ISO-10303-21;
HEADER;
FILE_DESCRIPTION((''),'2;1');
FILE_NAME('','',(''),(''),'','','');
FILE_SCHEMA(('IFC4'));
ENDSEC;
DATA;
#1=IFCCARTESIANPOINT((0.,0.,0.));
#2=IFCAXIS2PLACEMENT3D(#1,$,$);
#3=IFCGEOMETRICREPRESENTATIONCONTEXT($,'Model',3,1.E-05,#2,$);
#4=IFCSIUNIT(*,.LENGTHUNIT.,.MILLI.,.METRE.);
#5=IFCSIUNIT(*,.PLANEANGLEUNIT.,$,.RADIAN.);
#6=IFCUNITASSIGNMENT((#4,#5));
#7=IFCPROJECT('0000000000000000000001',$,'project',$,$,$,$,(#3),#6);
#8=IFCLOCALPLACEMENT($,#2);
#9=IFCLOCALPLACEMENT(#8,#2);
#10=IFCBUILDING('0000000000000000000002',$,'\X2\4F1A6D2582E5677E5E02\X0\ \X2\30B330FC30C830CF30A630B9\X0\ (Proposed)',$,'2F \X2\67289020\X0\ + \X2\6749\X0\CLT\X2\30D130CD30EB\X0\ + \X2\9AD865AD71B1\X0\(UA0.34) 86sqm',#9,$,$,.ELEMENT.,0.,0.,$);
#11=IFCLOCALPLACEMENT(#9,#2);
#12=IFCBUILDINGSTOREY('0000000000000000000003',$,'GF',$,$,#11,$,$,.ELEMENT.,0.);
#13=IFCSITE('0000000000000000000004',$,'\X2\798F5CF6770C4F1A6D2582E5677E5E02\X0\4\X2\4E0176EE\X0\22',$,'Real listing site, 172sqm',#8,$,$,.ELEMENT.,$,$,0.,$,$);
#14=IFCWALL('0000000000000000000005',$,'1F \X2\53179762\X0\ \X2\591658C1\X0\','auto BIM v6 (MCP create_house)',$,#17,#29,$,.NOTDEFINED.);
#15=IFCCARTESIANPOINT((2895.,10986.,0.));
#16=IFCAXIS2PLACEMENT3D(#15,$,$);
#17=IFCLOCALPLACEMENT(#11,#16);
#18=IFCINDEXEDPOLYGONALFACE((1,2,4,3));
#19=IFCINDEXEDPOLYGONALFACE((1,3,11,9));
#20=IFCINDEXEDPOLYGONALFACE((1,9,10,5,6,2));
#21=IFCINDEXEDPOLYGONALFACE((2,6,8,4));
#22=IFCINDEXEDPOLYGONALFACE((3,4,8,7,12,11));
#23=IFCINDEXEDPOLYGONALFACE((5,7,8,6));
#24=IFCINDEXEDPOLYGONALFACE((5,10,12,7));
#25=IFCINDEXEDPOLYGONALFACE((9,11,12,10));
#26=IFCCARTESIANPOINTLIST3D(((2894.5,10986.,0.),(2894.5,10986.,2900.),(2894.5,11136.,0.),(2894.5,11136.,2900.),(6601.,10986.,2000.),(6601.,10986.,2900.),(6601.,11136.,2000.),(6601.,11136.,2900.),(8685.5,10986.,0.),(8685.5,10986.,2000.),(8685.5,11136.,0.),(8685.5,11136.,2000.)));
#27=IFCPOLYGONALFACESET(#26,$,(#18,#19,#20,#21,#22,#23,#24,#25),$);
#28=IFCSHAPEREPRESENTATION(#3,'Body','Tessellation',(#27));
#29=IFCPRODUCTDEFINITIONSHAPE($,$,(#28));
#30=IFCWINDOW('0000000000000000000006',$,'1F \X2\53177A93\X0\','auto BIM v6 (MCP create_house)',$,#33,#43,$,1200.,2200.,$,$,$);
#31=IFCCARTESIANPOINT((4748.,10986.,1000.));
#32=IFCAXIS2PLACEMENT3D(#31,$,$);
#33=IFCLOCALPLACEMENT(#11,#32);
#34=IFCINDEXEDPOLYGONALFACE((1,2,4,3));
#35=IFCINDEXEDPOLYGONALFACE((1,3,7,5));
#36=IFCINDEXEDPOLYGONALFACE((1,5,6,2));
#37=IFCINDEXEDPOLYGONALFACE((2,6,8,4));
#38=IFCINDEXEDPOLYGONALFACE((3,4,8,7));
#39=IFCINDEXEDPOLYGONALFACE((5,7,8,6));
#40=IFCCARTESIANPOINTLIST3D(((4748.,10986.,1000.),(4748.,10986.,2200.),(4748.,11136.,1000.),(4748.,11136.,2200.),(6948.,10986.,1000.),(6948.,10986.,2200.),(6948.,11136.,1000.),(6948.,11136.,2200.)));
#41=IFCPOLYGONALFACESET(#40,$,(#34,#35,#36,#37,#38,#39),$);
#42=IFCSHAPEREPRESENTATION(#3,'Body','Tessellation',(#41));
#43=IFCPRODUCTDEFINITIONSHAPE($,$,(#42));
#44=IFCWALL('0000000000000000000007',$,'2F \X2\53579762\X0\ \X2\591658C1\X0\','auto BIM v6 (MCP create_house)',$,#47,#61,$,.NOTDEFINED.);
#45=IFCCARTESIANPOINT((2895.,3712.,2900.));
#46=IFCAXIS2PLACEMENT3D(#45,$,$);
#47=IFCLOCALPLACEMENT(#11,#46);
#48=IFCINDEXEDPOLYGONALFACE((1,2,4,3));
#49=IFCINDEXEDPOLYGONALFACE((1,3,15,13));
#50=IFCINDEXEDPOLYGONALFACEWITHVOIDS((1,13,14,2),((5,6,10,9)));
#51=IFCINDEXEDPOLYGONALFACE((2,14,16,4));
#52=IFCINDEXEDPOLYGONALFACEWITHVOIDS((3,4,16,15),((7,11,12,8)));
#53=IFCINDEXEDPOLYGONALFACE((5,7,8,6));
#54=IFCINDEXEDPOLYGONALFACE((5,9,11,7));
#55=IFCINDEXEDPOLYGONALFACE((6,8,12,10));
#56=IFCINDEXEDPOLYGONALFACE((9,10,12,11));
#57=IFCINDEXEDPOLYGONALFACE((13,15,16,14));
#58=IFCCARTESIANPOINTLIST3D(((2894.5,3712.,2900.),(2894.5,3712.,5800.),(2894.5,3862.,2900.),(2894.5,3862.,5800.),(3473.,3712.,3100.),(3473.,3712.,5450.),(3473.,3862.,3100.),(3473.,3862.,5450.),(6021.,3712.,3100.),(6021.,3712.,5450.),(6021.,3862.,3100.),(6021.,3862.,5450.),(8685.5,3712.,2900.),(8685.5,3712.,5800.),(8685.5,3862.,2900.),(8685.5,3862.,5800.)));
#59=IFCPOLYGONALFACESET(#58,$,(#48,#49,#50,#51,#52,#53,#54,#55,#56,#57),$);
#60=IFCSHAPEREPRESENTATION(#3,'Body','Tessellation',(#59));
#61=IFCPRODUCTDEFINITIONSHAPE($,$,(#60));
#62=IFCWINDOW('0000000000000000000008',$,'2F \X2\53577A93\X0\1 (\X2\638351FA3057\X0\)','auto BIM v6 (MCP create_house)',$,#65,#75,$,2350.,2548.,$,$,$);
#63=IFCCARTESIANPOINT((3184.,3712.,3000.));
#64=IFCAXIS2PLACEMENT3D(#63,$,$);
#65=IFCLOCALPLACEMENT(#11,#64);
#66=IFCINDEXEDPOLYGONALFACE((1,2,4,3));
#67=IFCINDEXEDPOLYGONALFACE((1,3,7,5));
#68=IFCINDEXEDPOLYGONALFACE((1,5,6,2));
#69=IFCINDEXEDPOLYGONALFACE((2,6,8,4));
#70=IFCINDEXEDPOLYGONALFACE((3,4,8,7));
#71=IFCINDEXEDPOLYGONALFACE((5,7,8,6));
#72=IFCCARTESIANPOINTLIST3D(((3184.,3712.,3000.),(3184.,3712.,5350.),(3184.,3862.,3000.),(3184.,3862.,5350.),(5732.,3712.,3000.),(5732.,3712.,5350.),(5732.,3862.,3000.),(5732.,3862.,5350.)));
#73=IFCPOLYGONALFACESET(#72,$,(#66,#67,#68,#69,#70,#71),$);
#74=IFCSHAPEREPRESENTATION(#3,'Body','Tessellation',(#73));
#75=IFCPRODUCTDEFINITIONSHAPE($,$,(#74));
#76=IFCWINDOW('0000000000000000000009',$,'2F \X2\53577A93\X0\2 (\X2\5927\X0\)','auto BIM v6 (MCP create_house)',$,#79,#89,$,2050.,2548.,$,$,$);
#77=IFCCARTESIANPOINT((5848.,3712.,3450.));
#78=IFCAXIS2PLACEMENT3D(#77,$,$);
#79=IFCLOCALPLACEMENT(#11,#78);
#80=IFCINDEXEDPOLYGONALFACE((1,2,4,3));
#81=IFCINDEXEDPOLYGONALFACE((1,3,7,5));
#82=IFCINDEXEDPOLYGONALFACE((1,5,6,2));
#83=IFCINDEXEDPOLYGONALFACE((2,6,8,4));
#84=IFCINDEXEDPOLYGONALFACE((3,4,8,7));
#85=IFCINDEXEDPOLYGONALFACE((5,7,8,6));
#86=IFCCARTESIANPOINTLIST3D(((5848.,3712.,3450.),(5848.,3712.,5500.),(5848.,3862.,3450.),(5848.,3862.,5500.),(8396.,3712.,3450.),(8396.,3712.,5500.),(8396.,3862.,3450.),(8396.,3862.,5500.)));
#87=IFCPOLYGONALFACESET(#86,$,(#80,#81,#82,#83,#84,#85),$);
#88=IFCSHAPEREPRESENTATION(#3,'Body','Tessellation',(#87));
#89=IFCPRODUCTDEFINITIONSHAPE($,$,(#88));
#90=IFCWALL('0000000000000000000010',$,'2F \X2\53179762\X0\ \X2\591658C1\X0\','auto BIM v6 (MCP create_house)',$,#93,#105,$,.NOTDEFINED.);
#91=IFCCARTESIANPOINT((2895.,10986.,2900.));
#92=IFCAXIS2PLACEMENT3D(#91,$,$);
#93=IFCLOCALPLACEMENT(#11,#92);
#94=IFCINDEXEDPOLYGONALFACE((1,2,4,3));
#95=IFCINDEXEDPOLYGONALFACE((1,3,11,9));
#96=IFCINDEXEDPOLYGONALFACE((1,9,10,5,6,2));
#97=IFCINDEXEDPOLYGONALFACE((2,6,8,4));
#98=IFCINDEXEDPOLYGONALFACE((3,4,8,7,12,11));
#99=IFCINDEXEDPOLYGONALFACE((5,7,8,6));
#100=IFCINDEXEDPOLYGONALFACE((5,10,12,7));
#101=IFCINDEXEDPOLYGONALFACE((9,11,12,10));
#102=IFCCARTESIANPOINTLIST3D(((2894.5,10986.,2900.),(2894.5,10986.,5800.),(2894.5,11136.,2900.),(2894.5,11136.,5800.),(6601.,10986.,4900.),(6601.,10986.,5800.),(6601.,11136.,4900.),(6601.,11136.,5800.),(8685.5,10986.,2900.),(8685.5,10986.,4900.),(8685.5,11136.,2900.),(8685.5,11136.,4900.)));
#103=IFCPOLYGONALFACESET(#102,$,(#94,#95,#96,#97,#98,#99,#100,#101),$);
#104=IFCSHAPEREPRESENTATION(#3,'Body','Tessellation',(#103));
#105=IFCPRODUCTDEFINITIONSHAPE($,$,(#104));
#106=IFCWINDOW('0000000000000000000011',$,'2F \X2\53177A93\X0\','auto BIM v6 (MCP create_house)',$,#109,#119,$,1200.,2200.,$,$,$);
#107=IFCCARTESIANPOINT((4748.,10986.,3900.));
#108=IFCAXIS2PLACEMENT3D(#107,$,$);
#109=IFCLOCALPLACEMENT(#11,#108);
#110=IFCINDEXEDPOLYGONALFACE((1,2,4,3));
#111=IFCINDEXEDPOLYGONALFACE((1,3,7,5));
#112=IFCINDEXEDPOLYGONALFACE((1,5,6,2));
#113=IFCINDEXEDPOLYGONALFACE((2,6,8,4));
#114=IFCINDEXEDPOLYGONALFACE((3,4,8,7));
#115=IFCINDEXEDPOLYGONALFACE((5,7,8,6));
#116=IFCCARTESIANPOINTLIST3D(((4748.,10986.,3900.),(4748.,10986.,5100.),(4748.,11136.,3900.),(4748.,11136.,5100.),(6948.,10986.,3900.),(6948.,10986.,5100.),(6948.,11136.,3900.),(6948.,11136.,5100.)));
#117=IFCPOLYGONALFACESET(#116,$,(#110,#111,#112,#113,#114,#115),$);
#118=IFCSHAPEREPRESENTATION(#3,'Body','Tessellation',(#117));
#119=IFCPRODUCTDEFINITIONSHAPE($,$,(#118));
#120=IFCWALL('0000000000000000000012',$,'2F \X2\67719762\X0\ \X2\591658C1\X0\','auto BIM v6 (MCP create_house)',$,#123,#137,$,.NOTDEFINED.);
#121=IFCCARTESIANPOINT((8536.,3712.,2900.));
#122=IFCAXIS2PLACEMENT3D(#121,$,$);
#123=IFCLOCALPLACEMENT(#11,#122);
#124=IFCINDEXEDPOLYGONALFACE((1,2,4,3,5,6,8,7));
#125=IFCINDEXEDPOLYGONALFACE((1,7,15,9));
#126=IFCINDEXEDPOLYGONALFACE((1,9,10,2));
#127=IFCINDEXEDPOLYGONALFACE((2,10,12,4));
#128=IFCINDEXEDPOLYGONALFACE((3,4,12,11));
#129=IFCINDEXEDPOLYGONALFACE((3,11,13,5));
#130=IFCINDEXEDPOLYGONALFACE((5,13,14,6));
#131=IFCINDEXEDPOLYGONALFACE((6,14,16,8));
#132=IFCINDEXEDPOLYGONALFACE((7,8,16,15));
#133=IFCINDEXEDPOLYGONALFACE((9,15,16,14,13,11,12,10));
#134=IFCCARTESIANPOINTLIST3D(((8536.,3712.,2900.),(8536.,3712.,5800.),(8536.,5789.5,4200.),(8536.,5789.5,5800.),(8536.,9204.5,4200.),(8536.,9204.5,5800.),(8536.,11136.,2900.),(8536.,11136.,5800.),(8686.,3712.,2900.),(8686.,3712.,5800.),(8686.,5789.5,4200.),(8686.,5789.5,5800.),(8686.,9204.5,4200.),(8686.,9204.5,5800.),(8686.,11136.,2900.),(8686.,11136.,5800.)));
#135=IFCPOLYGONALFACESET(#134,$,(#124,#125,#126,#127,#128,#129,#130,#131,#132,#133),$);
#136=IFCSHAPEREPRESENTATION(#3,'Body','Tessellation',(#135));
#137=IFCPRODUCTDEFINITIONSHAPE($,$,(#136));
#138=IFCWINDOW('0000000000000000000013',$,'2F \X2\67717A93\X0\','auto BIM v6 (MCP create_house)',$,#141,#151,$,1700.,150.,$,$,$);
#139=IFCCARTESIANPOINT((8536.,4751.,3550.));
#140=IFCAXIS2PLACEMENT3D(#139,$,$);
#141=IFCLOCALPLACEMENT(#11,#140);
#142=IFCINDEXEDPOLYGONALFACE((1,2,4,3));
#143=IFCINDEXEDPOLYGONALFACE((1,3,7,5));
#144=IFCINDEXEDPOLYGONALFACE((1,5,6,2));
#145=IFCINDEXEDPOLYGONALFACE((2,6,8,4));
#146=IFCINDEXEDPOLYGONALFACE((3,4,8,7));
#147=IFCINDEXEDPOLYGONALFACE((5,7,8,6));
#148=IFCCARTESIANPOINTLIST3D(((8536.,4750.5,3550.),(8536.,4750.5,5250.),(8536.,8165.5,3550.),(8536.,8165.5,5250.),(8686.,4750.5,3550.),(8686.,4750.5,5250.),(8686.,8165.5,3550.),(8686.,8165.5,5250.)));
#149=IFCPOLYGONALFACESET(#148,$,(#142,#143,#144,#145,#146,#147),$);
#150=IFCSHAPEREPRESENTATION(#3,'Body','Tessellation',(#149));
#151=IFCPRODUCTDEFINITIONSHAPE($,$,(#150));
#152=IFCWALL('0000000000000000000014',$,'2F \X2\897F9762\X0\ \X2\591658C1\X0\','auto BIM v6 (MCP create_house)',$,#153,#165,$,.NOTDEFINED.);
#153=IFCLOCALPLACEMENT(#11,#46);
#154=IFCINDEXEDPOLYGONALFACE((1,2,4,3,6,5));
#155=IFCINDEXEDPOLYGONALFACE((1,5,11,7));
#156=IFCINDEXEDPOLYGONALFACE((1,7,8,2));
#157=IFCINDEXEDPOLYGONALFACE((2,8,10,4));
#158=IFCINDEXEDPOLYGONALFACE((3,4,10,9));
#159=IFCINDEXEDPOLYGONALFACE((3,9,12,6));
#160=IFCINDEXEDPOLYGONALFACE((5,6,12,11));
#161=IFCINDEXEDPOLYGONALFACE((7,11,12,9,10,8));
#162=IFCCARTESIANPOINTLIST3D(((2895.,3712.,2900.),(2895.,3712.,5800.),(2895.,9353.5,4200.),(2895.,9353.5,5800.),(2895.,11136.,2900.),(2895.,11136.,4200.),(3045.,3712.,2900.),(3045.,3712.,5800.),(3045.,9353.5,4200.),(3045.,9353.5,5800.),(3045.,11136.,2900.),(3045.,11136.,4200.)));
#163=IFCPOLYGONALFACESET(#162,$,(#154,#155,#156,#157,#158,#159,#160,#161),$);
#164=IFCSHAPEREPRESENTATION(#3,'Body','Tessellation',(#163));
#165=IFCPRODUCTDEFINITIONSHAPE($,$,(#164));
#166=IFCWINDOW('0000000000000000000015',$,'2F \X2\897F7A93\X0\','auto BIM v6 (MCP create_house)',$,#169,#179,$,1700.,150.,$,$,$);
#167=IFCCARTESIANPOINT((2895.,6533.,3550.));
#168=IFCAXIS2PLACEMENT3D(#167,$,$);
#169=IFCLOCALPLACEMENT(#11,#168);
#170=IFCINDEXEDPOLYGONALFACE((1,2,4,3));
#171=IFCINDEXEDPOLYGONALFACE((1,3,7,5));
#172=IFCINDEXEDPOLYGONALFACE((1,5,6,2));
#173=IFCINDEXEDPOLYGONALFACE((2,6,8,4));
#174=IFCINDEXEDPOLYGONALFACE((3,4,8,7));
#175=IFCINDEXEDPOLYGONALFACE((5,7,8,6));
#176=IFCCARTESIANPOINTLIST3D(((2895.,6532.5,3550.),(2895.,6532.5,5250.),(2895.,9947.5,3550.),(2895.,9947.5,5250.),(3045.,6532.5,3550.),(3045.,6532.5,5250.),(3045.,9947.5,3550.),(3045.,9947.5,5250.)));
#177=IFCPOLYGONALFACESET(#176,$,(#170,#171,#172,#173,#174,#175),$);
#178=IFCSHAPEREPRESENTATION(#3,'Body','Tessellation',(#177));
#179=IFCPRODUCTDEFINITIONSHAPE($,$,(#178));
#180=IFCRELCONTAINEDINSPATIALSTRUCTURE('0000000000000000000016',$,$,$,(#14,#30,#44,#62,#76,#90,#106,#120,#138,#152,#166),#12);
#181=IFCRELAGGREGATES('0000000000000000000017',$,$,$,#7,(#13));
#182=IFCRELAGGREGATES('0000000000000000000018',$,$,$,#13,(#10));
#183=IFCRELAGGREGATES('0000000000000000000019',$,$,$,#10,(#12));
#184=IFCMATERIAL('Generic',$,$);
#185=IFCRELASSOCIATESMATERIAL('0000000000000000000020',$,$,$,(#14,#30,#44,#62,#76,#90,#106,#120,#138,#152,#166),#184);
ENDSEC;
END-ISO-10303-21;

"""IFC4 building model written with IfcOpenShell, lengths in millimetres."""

from ifc_helpers import new_model, si_unit, frame, frame_2d, origin, place, context, project, spatial, rectangle, extrude, material, element, fill, save


model = new_model("IFC4")

# Units and contexts
model_context = context("Model", 3, precision=1e-05, world=origin())
ifc_project = project(units=[si_unit("LENGTHUNIT", "METRE", prefix="MILLI"), si_unit("PLANEANGLEUNIT", "RADIAN")], contexts=[model_context])

# Site, building, storey
site_placement = place(None, origin())
site = spatial("IfcSite", under=ifc_project, at=site_placement, Name="福島県会津若松市4丁目22", ObjectType="Real listing site, 172sqm", CompositionType="ELEMENT", RefElevation=0.0)
building_placement = place(site_placement, origin())
building = spatial("IfcBuilding", under=site, at=building_placement, Name="会津若松市 コートハウス (Proposed)", ObjectType="2F 木造 + 杉CLTパネル + 高断熱(UA0.34) 86sqm", CompositionType="ELEMENT", ElevationOfRefHeight=0.0, ElevationOfTerrain=0.0)
storey_placement = place(building_placement, origin())
storey = spatial("IfcBuildingStorey", under=building, at=storey_placement, Name="GF", CompositionType="ELEMENT", Elevation=0.0)

# Wall, opening, window
ifc_material = material(Name="Generic")
wall_1_placement = place(storey_placement, frame((2895.0, 10986.0, 0.0)))
wall_1 = element("IfcWall", 1, at=wall_1_placement, inside=storey, material=ifc_material, Name="1F 北面 外壁", Description="auto BIM v6 (MCP create_house)", PredefinedType="NOTDEFINED", context=model_context, shape_type="SweptSolid", body=[
    extrude(rectangle(XDim=5791.0, YDim=150.0, at=frame_2d((2895.0, 75.0))), frame((2895.0, 10986.0, 0.0)), (0.0, 0.0, 1.0), 2900.0),
])
opening_1_placement = place(storey_placement, frame((4748.0, 10986.0, 1000.0)))
opening_1 = element("IfcOpeningElement", 2, at=opening_1_placement, cuts=wall_1, PredefinedType="NOTDEFINED", context=model_context, shape_type="SweptSolid", body=[
    extrude(rectangle(XDim=2200.0, YDim=150.0, at=frame_2d((1100.0, 75.0))), frame((4748.0, 10986.0, 1000.0)), (0.0, 0.0, 1.0), 1200.0),
])
window_1_placement = place(storey_placement, frame((4748.0, 10986.0, 1000.0)))
window_1 = element("IfcWindow", 3, at=window_1_placement, inside=storey, material=ifc_material, Name="1F 北窓", Description="auto BIM v6 (MCP create_house)", OverallHeight=1200.0, OverallWidth=2200.0, context=model_context, shape_type="SweptSolid", body=[
    extrude(rectangle(XDim=2200.0, YDim=150.0, at=frame_2d((1100.0, 75.0))), frame((4748.0, 10986.0, 1000.0)), (0.0, 0.0, 1.0), 1200.0),
])
fill(opening_1, window_1)

# Wall, openings, windows
wall_2_placement = place(storey_placement, frame((2895.0, 3712.0, 2900.0)))
wall_2 = element("IfcWall", 4, at=wall_2_placement, inside=storey, material=ifc_material, Name="2F 南面 外壁", Description="auto BIM v6 (MCP create_house)", PredefinedType="NOTDEFINED", context=model_context, shape_type="SweptSolid", body=[
    extrude(rectangle(XDim=5791.0, YDim=150.0, at=frame_2d((2895.0, 75.0))), frame((2895.0, 3712.0, 2900.0)), (0.0, 0.0, 1.0), 2900.0),
])
opening_2_placement = place(storey_placement, frame((3184.0, 3712.0, 3000.0)))
opening_2 = element("IfcOpeningElement", 5, at=opening_2_placement, cuts=wall_2, PredefinedType="NOTDEFINED", context=model_context, shape_type="SweptSolid", body=[
    extrude(rectangle(XDim=2548.0, YDim=150.0, at=frame_2d((1274.0, 75.0))), frame((3184.0, 3712.0, 3000.0)), (0.0, 0.0, 1.0), 2350.0),
])
opening_3_placement = place(storey_placement, frame((5848.0, 3712.0, 3450.0)))
opening_3 = element("IfcOpeningElement", 6, at=opening_3_placement, cuts=wall_2, PredefinedType="NOTDEFINED", context=model_context, shape_type="SweptSolid", body=[
    extrude(rectangle(XDim=2548.0, YDim=150.0, at=frame_2d((1274.0, 75.0))), frame((5848.0, 3712.0, 3450.0)), (0.0, 0.0, 1.0), 2050.0),
])
window_2_placement = place(storey_placement, frame((3184.0, 3712.0, 3000.0)))
window_2 = element("IfcWindow", 7, at=window_2_placement, inside=storey, material=ifc_material, Name="2F 南窓1 (掃出し)", Description="auto BIM v6 (MCP create_house)", OverallHeight=2350.0, OverallWidth=2548.0, context=model_context, shape_type="SweptSolid", body=[
    extrude(rectangle(XDim=2548.0, YDim=150.0, at=frame_2d((1274.0, 75.0))), frame((3184.0, 3712.0, 3000.0)), (0.0, 0.0, 1.0), 2350.0),
])
fill(opening_2, window_2)
window_3_placement = place(storey_placement, frame((5848.0, 3712.0, 3450.0)))
window_3 = element("IfcWindow", 8, at=window_3_placement, inside=storey, material=ifc_material, Name="2F 南窓2 (大)", Description="auto BIM v6 (MCP create_house)", OverallHeight=2050.0, OverallWidth=2548.0, context=model_context, shape_type="SweptSolid", body=[
    extrude(rectangle(XDim=2548.0, YDim=150.0, at=frame_2d((1274.0, 75.0))), frame((5848.0, 3712.0, 3450.0)), (0.0, 0.0, 1.0), 2050.0),
])
fill(opening_3, window_3)

# Walls, openings, windows
wall_3_placement = place(storey_placement, frame((2895.0, 10986.0, 2900.0)))
wall_3 = element("IfcWall", 9, at=wall_3_placement, inside=storey, material=ifc_material, Name="2F 北面 外壁", Description="auto BIM v6 (MCP create_house)", PredefinedType="NOTDEFINED", context=model_context, shape_type="SweptSolid", body=[
    extrude(rectangle(XDim=5791.0, YDim=150.0, at=frame_2d((2895.0, 75.0))), frame((2895.0, 10986.0, 2900.0)), (0.0, 0.0, 1.0), 2900.0),
])
opening_4_placement = place(storey_placement, frame((4748.0, 10986.0, 3900.0)))
opening_4 = element("IfcOpeningElement", 10, at=opening_4_placement, cuts=wall_3, PredefinedType="NOTDEFINED", context=model_context, shape_type="SweptSolid", body=[
    extrude(rectangle(XDim=2200.0, YDim=150.0, at=frame_2d((1100.0, 75.0))), frame((4748.0, 10986.0, 3900.0)), (0.0, 0.0, 1.0), 1200.0),
])
window_4_placement = place(storey_placement, frame((4748.0, 10986.0, 3900.0)))
window_4 = element("IfcWindow", 11, at=window_4_placement, inside=storey, material=ifc_material, Name="2F 北窓", Description="auto BIM v6 (MCP create_house)", OverallHeight=1200.0, OverallWidth=2200.0, context=model_context, shape_type="SweptSolid", body=[
    extrude(rectangle(XDim=2200.0, YDim=150.0, at=frame_2d((1100.0, 75.0))), frame((4748.0, 10986.0, 3900.0)), (0.0, 0.0, 1.0), 1200.0),
])
fill(opening_4, window_4)
wall_4_placement = place(storey_placement, frame((8536.0, 3712.0, 2900.0)))
wall_4 = element("IfcWall", 12, at=wall_4_placement, inside=storey, material=ifc_material, Name="2F 東面 外壁", Description="auto BIM v6 (MCP create_house)", PredefinedType="NOTDEFINED", context=model_context, shape_type="SweptSolid", body=[
    extrude(rectangle(XDim=150.0, YDim=7424.0, at=frame_2d((75.0, 3712.0))), frame((8536.0, 3712.0, 2900.0)), (0.0, 0.0, 1.0), 2900.0),
])
opening_5_placement = place(storey_placement, frame((8536.0, 4751.0, 3550.0)))
opening_5 = element("IfcOpeningElement", 13, at=opening_5_placement, cuts=wall_4, PredefinedType="NOTDEFINED", context=model_context, shape_type="SweptSolid", body=[
    extrude(rectangle(XDim=150.0, YDim=3415.0, at=frame_2d((75.0, 1707.0))), frame((8536.0, 4751.0, 3550.0)), (0.0, 0.0, 1.0), 1700.0),
])
window_5_placement = place(storey_placement, frame((8536.0, 4751.0, 3550.0)))
window_5 = element("IfcWindow", 14, at=window_5_placement, inside=storey, material=ifc_material, Name="2F 東窓", Description="auto BIM v6 (MCP create_house)", OverallHeight=1700.0, OverallWidth=150.0, context=model_context, shape_type="SweptSolid", body=[
    extrude(rectangle(XDim=150.0, YDim=3415.0, at=frame_2d((75.0, 1707.0))), frame((8536.0, 4751.0, 3550.0)), (0.0, 0.0, 1.0), 1700.0),
])
fill(opening_5, window_5)
wall_5_placement = place(storey_placement, frame((2895.0, 3712.0, 2900.0)))
wall_5 = element("IfcWall", 15, at=wall_5_placement, inside=storey, material=ifc_material, Name="2F 西面 外壁", Description="auto BIM v6 (MCP create_house)", PredefinedType="NOTDEFINED", context=model_context, shape_type="SweptSolid", body=[
    extrude(rectangle(XDim=150.0, YDim=7424.0, at=frame_2d((75.0, 3712.0))), frame((2895.0, 3712.0, 2900.0)), (0.0, 0.0, 1.0), 2900.0),
])
opening_6_placement = place(storey_placement, frame((2895.0, 6533.0, 3550.0)))
opening_6 = element("IfcOpeningElement", 16, at=opening_6_placement, cuts=wall_5, PredefinedType="NOTDEFINED", context=model_context, shape_type="SweptSolid", body=[
    extrude(rectangle(XDim=150.0, YDim=3415.0, at=frame_2d((75.0, 1707.0))), frame((2895.0, 6533.0, 3550.0)), (0.0, 0.0, 1.0), 1700.0),
])
window_6_placement = place(storey_placement, frame((2895.0, 6533.0, 3550.0)))
window_6 = element("IfcWindow", 17, at=window_6_placement, inside=storey, material=ifc_material, Name="2F 西窓", Description="auto BIM v6 (MCP create_house)", OverallHeight=1700.0, OverallWidth=150.0, context=model_context, shape_type="SweptSolid", body=[
    extrude(rectangle(XDim=150.0, YDim=3415.0, at=frame_2d((75.0, 1707.0))), frame((2895.0, 6533.0, 3550.0)), (0.0, 0.0, 1.0), 1700.0),
])
fill(opening_6, window_6)

save(model, "model.ifc")
